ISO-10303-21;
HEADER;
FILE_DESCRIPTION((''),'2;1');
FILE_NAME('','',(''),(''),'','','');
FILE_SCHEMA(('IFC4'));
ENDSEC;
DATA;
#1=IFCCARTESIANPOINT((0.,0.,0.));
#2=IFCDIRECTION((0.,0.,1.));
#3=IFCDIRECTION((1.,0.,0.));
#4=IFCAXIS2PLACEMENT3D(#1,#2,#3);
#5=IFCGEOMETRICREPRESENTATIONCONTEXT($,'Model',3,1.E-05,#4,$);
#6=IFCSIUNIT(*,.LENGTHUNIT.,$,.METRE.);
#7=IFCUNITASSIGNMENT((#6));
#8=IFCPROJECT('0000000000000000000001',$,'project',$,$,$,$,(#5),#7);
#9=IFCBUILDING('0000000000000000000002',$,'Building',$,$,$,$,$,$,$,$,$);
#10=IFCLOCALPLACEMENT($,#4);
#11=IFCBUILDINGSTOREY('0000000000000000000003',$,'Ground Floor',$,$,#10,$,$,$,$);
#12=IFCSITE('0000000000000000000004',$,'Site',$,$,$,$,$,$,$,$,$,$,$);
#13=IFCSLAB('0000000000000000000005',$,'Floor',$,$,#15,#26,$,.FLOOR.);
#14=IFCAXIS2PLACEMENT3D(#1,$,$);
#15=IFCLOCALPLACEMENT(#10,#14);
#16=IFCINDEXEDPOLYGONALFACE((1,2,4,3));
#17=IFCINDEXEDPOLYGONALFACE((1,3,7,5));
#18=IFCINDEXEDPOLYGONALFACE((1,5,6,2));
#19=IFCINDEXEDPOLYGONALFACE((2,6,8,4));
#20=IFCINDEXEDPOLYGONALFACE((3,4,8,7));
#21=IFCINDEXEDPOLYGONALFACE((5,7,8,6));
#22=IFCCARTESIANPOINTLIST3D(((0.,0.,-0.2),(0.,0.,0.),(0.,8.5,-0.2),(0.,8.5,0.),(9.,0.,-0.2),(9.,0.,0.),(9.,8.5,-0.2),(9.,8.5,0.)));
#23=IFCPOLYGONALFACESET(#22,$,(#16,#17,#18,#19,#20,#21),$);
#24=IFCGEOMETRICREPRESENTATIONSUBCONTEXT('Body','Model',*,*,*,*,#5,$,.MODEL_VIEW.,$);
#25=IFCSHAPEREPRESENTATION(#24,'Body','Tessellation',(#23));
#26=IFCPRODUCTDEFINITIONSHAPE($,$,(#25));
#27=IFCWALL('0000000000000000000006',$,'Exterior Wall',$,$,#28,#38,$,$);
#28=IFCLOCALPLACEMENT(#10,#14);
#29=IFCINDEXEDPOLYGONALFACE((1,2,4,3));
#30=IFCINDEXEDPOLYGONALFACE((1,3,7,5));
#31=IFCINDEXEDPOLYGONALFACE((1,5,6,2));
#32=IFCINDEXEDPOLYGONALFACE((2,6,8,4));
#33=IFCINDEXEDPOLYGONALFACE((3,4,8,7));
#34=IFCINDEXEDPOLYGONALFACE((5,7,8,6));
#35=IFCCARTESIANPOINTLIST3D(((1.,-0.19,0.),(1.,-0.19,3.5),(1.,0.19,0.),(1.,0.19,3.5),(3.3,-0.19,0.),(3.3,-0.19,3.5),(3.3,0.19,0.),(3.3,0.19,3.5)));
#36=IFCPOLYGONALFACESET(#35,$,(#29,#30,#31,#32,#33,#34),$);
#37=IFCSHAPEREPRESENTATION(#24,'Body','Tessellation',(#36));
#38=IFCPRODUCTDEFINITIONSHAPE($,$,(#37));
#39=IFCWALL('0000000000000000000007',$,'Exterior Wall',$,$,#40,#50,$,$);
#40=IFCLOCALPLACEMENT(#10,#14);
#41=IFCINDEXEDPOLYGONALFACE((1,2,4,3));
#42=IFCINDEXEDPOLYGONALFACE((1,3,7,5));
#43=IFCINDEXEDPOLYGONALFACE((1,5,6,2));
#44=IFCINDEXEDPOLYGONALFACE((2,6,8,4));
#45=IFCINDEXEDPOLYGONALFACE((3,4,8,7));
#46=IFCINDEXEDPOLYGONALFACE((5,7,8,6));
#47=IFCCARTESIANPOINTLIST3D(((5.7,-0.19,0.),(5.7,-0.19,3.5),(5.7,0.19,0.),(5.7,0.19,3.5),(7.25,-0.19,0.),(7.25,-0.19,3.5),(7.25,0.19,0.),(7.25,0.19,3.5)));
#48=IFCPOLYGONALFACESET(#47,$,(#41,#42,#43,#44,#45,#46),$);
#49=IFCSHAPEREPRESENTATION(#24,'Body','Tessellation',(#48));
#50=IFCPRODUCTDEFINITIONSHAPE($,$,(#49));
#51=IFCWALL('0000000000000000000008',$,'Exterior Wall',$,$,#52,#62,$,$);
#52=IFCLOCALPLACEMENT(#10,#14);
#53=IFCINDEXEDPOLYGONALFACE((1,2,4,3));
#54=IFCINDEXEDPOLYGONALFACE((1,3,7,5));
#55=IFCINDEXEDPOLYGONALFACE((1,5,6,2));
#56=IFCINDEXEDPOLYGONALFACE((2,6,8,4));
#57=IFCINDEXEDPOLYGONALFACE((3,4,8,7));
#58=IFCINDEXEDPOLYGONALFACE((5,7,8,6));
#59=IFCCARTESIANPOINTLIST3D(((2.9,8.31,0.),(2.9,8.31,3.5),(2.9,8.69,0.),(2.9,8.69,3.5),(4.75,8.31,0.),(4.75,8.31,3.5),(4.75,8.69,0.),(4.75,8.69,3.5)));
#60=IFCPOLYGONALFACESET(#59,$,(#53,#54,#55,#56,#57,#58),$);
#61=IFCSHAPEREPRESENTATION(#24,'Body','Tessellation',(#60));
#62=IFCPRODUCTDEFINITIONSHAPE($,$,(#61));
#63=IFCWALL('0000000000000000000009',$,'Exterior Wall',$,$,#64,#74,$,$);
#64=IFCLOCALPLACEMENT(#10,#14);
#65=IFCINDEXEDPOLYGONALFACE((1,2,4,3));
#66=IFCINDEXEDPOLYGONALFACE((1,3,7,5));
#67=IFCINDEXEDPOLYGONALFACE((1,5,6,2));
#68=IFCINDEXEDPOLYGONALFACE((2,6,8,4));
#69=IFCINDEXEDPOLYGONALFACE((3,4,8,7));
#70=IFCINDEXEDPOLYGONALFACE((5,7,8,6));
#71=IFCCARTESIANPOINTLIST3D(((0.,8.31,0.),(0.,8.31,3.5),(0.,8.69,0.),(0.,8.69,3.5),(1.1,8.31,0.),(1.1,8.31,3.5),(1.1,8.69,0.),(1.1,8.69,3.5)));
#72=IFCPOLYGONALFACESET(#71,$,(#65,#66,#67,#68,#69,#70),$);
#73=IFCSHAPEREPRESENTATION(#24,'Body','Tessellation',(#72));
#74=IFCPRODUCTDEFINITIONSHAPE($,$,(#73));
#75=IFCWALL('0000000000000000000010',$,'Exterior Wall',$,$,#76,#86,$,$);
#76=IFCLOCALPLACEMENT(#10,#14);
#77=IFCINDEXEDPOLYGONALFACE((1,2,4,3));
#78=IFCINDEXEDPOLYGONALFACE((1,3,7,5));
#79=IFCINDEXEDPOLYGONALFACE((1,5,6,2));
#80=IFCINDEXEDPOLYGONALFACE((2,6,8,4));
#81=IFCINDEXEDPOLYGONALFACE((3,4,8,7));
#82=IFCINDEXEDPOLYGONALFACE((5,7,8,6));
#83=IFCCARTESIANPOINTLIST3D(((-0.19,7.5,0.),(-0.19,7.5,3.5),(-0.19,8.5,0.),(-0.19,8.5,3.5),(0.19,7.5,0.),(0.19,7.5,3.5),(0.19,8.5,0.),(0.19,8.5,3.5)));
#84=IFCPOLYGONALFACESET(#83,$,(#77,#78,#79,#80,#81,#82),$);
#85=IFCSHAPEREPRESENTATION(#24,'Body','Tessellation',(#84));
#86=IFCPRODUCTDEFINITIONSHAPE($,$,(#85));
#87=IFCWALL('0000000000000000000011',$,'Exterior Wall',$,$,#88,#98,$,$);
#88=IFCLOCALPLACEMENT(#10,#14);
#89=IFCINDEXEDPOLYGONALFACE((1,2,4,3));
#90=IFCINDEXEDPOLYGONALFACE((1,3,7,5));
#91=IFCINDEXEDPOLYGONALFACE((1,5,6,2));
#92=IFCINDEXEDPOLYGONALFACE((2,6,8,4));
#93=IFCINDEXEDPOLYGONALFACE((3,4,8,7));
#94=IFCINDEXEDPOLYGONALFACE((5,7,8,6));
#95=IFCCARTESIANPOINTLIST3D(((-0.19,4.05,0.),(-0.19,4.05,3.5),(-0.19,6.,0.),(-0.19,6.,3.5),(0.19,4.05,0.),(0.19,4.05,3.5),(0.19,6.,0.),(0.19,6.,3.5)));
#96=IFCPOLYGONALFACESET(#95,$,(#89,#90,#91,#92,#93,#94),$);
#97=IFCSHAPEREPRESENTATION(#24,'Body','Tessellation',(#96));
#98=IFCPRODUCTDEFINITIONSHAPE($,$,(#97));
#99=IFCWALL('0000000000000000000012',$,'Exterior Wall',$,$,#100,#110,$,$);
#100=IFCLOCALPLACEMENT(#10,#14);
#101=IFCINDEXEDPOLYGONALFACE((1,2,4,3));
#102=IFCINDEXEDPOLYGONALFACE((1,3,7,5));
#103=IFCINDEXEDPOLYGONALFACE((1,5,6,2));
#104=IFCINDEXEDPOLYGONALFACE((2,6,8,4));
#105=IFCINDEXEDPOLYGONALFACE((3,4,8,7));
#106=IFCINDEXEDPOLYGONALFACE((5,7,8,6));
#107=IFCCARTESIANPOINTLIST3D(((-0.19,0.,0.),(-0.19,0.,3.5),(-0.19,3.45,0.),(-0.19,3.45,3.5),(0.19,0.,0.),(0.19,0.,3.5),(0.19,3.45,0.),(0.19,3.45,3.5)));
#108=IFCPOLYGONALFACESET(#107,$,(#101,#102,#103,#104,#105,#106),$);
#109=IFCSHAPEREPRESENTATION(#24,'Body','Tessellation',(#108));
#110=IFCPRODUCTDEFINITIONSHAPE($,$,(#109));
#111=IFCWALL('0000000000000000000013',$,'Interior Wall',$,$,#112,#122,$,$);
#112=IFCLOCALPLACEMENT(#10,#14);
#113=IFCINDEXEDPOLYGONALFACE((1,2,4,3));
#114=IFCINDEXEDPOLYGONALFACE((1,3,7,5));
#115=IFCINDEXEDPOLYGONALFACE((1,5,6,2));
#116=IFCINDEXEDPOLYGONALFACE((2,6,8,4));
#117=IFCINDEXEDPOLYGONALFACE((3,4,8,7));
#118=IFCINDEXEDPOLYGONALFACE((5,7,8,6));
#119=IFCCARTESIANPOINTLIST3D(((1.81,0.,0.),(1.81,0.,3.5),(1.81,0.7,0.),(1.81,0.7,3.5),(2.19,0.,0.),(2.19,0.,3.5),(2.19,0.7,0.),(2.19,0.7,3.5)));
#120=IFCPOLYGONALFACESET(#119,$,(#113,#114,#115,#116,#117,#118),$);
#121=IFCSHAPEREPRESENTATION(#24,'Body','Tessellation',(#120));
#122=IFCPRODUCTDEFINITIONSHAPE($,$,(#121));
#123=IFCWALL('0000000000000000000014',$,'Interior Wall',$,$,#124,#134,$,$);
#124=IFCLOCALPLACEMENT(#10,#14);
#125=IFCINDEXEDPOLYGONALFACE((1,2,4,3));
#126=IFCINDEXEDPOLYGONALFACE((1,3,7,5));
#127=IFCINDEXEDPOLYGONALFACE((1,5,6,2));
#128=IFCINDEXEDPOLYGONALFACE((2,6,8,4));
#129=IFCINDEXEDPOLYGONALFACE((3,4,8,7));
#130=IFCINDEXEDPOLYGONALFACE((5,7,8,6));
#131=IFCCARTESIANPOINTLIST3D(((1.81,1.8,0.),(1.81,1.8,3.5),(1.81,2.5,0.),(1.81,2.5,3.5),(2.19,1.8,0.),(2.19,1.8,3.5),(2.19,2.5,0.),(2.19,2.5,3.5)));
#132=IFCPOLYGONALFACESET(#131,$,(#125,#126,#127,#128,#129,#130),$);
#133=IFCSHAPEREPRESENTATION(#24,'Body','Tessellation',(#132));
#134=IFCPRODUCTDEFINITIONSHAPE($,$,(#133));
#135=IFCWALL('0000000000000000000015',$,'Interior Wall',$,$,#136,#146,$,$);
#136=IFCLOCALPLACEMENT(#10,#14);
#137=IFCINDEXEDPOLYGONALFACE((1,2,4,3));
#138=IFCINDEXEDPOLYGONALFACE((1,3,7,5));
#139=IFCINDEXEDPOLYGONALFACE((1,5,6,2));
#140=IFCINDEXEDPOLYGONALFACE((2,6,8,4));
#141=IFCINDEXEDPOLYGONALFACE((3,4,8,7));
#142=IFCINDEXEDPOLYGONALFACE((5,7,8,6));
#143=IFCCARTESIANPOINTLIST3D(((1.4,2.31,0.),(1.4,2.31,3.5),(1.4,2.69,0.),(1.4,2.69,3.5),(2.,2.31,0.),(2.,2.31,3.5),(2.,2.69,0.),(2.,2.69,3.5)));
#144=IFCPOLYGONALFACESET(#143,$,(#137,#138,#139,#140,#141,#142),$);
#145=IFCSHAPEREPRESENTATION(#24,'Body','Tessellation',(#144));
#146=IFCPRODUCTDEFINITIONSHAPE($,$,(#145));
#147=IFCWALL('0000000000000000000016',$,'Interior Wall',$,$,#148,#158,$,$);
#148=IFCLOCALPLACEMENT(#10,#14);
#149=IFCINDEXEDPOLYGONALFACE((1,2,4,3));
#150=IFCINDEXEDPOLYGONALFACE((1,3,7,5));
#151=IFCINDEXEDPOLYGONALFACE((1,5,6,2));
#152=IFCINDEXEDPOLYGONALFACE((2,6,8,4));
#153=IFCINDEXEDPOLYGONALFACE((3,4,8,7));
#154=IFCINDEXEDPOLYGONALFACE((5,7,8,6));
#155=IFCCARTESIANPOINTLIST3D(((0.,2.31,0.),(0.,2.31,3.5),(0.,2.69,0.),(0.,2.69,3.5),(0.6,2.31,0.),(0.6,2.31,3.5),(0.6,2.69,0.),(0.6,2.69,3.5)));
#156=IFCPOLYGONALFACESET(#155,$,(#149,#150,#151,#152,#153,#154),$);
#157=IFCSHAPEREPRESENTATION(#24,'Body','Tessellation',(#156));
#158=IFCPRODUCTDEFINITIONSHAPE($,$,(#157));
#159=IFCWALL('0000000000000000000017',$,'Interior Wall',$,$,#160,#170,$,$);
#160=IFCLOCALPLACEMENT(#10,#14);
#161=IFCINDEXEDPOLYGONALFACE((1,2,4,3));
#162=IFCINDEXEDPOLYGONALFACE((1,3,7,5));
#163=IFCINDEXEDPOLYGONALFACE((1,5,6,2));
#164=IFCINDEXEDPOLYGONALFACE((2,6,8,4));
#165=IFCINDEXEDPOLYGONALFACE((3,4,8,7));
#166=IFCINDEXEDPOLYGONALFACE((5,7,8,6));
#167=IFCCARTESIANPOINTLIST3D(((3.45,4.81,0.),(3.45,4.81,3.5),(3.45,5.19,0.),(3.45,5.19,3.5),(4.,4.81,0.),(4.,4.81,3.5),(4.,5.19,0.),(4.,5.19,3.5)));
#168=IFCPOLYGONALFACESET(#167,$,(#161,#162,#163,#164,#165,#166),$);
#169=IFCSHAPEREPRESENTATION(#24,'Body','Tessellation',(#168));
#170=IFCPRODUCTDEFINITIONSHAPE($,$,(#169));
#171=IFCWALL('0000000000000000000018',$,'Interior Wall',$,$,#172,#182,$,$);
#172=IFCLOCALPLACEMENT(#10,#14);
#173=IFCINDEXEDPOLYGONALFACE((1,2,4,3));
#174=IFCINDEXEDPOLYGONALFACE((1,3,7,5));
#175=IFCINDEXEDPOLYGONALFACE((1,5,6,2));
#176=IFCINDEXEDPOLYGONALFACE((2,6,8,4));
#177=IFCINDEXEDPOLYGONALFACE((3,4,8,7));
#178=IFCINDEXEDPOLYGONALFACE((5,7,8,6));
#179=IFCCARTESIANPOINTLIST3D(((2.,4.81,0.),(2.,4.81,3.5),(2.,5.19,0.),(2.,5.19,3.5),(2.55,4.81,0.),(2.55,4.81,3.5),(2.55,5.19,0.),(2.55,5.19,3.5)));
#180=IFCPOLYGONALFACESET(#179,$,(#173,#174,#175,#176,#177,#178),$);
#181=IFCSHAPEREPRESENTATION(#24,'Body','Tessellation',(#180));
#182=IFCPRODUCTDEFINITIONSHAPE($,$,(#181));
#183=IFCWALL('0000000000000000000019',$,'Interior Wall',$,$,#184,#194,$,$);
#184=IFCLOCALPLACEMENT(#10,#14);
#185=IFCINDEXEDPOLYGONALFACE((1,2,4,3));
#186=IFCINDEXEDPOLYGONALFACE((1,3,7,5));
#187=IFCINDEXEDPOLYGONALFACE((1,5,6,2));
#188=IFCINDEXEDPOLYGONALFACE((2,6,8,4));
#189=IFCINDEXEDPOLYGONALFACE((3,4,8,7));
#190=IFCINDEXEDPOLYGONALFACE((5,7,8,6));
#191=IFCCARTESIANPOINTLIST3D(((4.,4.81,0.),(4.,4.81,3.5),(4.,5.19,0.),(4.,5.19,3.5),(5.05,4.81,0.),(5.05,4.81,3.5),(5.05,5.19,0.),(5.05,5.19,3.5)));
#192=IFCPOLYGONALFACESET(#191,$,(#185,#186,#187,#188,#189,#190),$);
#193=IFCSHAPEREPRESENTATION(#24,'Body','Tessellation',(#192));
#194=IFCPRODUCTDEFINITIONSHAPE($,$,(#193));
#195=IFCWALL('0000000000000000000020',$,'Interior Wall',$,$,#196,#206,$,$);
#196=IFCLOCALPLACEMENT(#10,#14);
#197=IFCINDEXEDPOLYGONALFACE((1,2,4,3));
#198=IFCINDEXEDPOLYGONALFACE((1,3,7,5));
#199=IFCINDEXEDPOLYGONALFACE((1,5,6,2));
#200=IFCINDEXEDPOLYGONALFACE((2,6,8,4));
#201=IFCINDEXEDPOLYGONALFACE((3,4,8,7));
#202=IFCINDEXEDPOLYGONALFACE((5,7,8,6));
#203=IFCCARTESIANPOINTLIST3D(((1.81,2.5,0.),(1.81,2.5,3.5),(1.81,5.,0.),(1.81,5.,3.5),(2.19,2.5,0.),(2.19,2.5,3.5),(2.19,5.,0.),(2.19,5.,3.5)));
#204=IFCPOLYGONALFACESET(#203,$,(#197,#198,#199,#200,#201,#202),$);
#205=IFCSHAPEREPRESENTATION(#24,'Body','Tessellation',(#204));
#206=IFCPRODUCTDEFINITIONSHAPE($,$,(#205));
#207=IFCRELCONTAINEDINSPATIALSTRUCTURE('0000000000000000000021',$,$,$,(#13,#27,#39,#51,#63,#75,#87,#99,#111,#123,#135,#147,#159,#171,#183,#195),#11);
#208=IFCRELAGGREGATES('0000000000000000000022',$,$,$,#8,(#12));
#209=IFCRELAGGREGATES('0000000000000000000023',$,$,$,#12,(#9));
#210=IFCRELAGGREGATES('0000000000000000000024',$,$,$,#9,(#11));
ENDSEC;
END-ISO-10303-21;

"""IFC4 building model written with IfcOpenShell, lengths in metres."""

from ifc_helpers import new_model, si_unit, frame, origin_with_axes, place, context, subcontext, project, spatial, indexed_curve, outline, extrude, element, save


model = new_model("IFC4")

# Units and contexts
model_context = context("Model", 3, precision=1e-05, world=origin_with_axes())
body_context = subcontext(model_context, "Body", "Model", "MODEL_VIEW")
ifc_project = project(units=[si_unit("LENGTHUNIT", "METRE")], contexts=[model_context])

# Site, building, storey
site = spatial("IfcSite", under=ifc_project, Name="Site")
building = spatial("IfcBuilding", under=site, Name="Building")
storey_placement = place(None, origin_with_axes())
storey = spatial("IfcBuildingStorey", under=building, at=storey_placement, Name="Ground Floor")

# Slab
slab_placement = place(storey_placement, frame((0.0, 0.0, -0.2), z_axis=(0.0, 0.0, 1.0), x_axis=(1.0, 0.0, 0.0)))
element("IfcSlab", 1, at=slab_placement, inside=storey, Name="Floor", PredefinedType="FLOOR", context=body_context, shape_type="SweptSolid", body=[
    extrude(outline(indexed_curve([(0.0, 0.0), (9.0, 0.0), (9.0, 8.5), (0.0, 8.5)])), None, (0.0, 0.0, 1.0), 0.2),
])

# Walls
wall_1_placement = place(storey_placement, frame((1.0, 0.0, 0.0), z_axis=(0.0, 0.0, 1.0), x_axis=(1.0, 0.0, 0.0)))
element("IfcWall", 2, at=wall_1_placement, inside=storey, Name="Exterior Wall", context=body_context, shape_type="SweptSolid", body=[
    extrude(outline(indexed_curve([(0.0, 0.0), (0.0, 0.38), (2.3, 0.38), (2.3, 0.0), (0.0, 0.0)], self_intersect=False)), frame((0.0, -0.19, 0.0), z_axis=(0.0, 0.0, 1.0), x_axis=(1.0, 0.0, 0.0)), (0.0, 0.0, 1.0), 3.5),
])
wall_2_placement = place(storey_placement, frame((5.7, 0.0, 0.0), z_axis=(0.0, 0.0, 1.0), x_axis=(1.0, 0.0, 0.0)))
element("IfcWall", 3, at=wall_2_placement, inside=storey, Name="Exterior Wall", context=body_context, shape_type="SweptSolid", body=[
    extrude(outline(indexed_curve([(0.0, 0.0), (0.0, 0.38), (1.55, 0.38), (1.55, 0.0), (0.0, 0.0)], self_intersect=False)), frame((0.0, -0.19, 0.0), z_axis=(0.0, 0.0, 1.0), x_axis=(1.0, 0.0, 0.0)), (0.0, 0.0, 1.0), 3.5),
])
wall_3_placement = place(storey_placement, frame((4.75, 8.5, 0.0), z_axis=(0.0, 0.0, 1.0), x_axis=(-1.0, 0.0, 0.0)))
element("IfcWall", 4, at=wall_3_placement, inside=storey, Name="Exterior Wall", context=body_context, shape_type="SweptSolid", body=[
    extrude(outline(indexed_curve([(0.0, 0.0), (0.0, 0.38), (1.85, 0.38), (1.85, 0.0), (0.0, 0.0)], self_intersect=False)), frame((0.0, -0.19, 0.0), z_axis=(0.0, 0.0, 1.0), x_axis=(1.0, 0.0, 0.0)), (0.0, 0.0, 1.0), 3.5),
])
wall_4_placement = place(storey_placement, frame((1.1, 8.5, 0.0), z_axis=(0.0, 0.0, 1.0), x_axis=(-1.0, 0.0, 0.0)))
element("IfcWall", 5, at=wall_4_placement, inside=storey, Name="Exterior Wall", context=body_context, shape_type="SweptSolid", body=[
    extrude(outline(indexed_curve([(0.0, 0.0), (0.0, 0.38), (1.1, 0.38), (1.1, 0.0), (0.0, 0.0)], self_intersect=False)), frame((0.0, -0.19, 0.0), z_axis=(0.0, 0.0, 1.0), x_axis=(1.0, 0.0, 0.0)), (0.0, 0.0, 1.0), 3.5),
])
wall_5_placement = place(storey_placement, frame((0.0, 8.5, 0.0), z_axis=(0.0, 0.0, 1.0), x_axis=(0.0, -1.0, 0.0)))
element("IfcWall", 6, at=wall_5_placement, inside=storey, Name="Exterior Wall", context=body_context, shape_type="SweptSolid", body=[
    extrude(outline(indexed_curve([(0.0, 0.0), (0.0, 0.38), (1.0, 0.38), (1.0, 0.0), (0.0, 0.0)], self_intersect=False)), frame((0.0, -0.19, 0.0), z_axis=(0.0, 0.0, 1.0), x_axis=(1.0, 0.0, 0.0)), (0.0, 0.0, 1.0), 3.5),
])
wall_6_placement = place(storey_placement, frame((0.0, 6.0, 0.0), z_axis=(0.0, 0.0, 1.0), x_axis=(0.0, -1.0, 0.0)))
element("IfcWall", 7, at=wall_6_placement, inside=storey, Name="Exterior Wall", context=body_context, shape_type="SweptSolid", body=[
    extrude(outline(indexed_curve([(0.0, 0.0), (0.0, 0.38), (1.95, 0.38), (1.95, 0.0), (0.0, 0.0)], self_intersect=False)), frame((0.0, -0.19, 0.0), z_axis=(0.0, 0.0, 1.0), x_axis=(1.0, 0.0, 0.0)), (0.0, 0.0, 1.0), 3.5),
])
wall_7_placement = place(storey_placement, frame((0.0, 3.45, 0.0), z_axis=(0.0, 0.0, 1.0), x_axis=(0.0, -1.0, 0.0)))
element("IfcWall", 8, at=wall_7_placement, inside=storey, Name="Exterior Wall", context=body_context, shape_type="SweptSolid", body=[
    extrude(outline(indexed_curve([(0.0, 0.0), (0.0, 0.38), (3.45, 0.38), (3.45, 0.0), (0.0, 0.0)], self_intersect=False)), frame((0.0, -0.19, 0.0), z_axis=(0.0, 0.0, 1.0), x_axis=(1.0, 0.0, 0.0)), (0.0, 0.0, 1.0), 3.5),
])
for number, where, z_axis, x_axis, name in (
    (9, (2.0, 0.0, 0.0), (0.0, 0.0, 1.0), (0.0, 1.0, 0.0), "Interior Wall"),
    (10, (2.0, 1.8, 0.0), (0.0, 0.0, 1.0), (0.0, 1.0, 0.0), "Interior Wall"),
):
    element("IfcWall", number, at=place(storey_placement, frame(where, z_axis=z_axis, x_axis=x_axis)), inside=storey, Name=name, context=body_context, shape_type="SweptSolid", body=[
        extrude(outline(indexed_curve([(0.0, 0.0), (0.0, 0.38), (0.7, 0.38), (0.7, 0.0), (0.0, 0.0)], self_intersect=False)), frame((0.0, -0.19, 0.0), z_axis=(0.0, 0.0, 1.0), x_axis=(1.0, 0.0, 0.0)), (0.0, 0.0, 1.0), 3.5),
    ])
for number, where, z_axis, x_axis, name in (
    (11, (2.0, 2.5, 0.0), (0.0, 0.0, 1.0), (-1.0, 0.0, 0.0), "Interior Wall"),
    (12, (0.6, 2.5, 0.0), (0.0, 0.0, 1.0), (-1.0, 0.0, 0.0), "Interior Wall"),
):
    element("IfcWall", number, at=place(storey_placement, frame(where, z_axis=z_axis, x_axis=x_axis)), inside=storey, Name=name, context=body_context, shape_type="SweptSolid", body=[
        extrude(outline(indexed_curve([(0.0, 0.0), (0.0, 0.38), (0.6, 0.38), (0.6, 0.0), (0.0, 0.0)], self_intersect=False)), frame((0.0, -0.19, 0.0), z_axis=(0.0, 0.0, 1.0), x_axis=(1.0, 0.0, 0.0)), (0.0, 0.0, 1.0), 3.5),
    ])
for number, where, z_axis, x_axis, name in (
    (13, (4.0, 5.0, 0.0), (0.0, 0.0, 1.0), (-1.0, 0.0, 0.0), "Interior Wall"),
    (14, (2.55, 5.0, 0.0), (0.0, 0.0, 1.0), (-1.0, 0.0, 0.0), "Interior Wall"),
):
    element("IfcWall", number, at=place(storey_placement, frame(where, z_axis=z_axis, x_axis=x_axis)), inside=storey, Name=name, context=body_context, shape_type="SweptSolid", body=[
        extrude(outline(indexed_curve([(0.0, 0.0), (0.0, 0.38), (0.55, 0.38), (0.55, 0.0), (0.0, 0.0)], self_intersect=False)), frame((0.0, -0.19, 0.0), z_axis=(0.0, 0.0, 1.0), x_axis=(1.0, 0.0, 0.0)), (0.0, 0.0, 1.0), 3.5),
    ])
wall_8_placement = place(storey_placement, frame((5.05, 5.0, 0.0), z_axis=(0.0, 0.0, 1.0), x_axis=(-1.0, 0.0, 0.0)))
element("IfcWall", 15, at=wall_8_placement, inside=storey, Name="Interior Wall", context=body_context, shape_type="SweptSolid", body=[
    extrude(outline(indexed_curve([(0.0, 0.0), (0.0, 0.38), (1.05, 0.38), (1.05, 0.0), (0.0, 0.0)], self_intersect=False)), frame((0.0, -0.19, 0.0), z_axis=(0.0, 0.0, 1.0), x_axis=(1.0, 0.0, 0.0)), (0.0, 0.0, 1.0), 3.5),
])
wall_9_placement = place(storey_placement, frame((2.0, 5.0, 0.0), z_axis=(0.0, 0.0, 1.0), x_axis=(0.0, -1.0, 0.0)))
element("IfcWall", 16, at=wall_9_placement, inside=storey, Name="Interior Wall", context=body_context, shape_type="SweptSolid", body=[
    extrude(outline(indexed_curve([(0.0, 0.0), (0.0, 0.38), (2.5, 0.38), (2.5, 0.0), (0.0, 0.0)], self_intersect=False)), frame((0.0, -0.19, 0.0), z_axis=(0.0, 0.0, 1.0), x_axis=(1.0, 0.0, 0.0)), (0.0, 0.0, 1.0), 3.5),
])

save(model, "model.ifc")
